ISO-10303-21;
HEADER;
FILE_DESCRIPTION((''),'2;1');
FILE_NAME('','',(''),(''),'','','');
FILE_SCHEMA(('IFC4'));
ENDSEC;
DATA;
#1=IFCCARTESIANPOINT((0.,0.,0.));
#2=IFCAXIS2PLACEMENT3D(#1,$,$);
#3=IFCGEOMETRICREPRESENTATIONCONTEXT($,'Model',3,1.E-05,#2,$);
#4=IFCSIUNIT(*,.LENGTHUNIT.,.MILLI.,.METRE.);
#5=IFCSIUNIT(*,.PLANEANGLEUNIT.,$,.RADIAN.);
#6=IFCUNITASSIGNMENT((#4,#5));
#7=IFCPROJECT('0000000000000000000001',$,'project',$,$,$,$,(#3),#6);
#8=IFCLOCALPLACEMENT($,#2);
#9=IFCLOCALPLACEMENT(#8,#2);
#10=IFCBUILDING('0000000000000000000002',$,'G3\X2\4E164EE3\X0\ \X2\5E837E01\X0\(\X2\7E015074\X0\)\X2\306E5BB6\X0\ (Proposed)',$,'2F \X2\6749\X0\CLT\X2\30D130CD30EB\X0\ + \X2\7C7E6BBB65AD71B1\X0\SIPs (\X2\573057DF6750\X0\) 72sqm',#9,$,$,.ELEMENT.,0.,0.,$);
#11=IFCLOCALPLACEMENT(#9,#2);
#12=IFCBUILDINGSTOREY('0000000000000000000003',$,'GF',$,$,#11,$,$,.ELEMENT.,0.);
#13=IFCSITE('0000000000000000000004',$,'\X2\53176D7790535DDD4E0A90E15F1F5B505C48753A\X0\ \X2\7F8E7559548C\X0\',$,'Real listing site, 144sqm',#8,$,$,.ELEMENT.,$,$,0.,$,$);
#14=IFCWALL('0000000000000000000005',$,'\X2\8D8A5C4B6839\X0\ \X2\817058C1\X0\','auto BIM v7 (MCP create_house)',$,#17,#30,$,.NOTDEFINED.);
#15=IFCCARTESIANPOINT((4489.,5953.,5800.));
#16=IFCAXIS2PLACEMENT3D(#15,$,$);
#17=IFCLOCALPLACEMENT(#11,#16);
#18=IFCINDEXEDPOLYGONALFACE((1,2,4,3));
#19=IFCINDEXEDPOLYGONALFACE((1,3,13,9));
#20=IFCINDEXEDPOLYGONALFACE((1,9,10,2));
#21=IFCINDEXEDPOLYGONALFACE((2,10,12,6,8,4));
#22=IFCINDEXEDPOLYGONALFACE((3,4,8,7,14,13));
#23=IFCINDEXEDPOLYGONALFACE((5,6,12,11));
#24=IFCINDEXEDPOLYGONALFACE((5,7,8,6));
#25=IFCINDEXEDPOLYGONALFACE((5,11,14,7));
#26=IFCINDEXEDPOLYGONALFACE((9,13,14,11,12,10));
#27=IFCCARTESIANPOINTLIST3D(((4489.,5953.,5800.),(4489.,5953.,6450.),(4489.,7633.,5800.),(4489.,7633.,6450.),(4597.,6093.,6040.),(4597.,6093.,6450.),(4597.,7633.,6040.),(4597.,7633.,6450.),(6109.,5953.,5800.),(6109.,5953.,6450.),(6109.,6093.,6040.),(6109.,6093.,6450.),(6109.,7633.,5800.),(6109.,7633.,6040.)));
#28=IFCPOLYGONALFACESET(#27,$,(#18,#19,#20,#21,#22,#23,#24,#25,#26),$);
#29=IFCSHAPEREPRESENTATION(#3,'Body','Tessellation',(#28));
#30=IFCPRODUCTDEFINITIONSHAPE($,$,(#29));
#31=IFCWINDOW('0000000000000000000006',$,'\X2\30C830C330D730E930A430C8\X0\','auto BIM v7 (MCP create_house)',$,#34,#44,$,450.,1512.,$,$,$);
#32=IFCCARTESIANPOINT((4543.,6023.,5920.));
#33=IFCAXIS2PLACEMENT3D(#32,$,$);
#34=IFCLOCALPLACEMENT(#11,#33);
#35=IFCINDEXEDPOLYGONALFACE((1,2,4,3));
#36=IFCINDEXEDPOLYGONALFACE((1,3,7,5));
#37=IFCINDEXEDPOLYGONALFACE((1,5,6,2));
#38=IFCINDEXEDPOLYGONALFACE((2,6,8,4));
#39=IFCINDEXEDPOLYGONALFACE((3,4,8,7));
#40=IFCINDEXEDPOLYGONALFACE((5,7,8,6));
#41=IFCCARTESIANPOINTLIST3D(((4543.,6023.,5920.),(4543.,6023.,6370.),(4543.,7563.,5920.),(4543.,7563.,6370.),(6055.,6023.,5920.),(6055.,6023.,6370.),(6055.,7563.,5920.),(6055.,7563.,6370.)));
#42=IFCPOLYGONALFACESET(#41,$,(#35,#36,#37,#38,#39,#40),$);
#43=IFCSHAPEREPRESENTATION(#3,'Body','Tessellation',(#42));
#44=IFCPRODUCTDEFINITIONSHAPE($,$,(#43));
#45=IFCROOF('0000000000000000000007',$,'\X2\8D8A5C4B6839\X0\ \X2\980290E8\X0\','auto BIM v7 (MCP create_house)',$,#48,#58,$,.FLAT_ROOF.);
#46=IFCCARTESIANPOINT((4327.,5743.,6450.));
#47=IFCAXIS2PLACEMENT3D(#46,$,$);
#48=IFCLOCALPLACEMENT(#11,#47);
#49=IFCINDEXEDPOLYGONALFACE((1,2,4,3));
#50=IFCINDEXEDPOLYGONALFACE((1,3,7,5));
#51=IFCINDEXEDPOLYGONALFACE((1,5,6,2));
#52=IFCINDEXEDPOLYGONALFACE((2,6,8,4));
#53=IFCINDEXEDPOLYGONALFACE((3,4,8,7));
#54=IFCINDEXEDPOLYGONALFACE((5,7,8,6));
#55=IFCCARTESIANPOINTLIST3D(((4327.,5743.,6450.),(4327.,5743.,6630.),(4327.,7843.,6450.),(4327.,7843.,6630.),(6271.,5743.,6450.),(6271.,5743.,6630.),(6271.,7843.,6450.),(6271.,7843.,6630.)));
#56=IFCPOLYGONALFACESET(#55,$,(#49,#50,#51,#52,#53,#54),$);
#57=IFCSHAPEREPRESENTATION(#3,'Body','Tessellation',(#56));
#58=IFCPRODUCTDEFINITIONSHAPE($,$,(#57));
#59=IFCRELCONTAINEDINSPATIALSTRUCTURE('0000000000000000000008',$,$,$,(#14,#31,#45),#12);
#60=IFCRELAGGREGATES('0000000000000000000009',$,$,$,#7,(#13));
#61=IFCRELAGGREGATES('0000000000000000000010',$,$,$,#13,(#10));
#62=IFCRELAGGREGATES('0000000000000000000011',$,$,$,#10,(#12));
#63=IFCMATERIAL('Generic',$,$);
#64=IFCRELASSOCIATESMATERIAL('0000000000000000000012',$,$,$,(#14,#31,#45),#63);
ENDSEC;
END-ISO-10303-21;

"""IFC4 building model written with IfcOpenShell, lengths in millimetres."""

from ifc_helpers import new_model, si_unit, frame, frame_2d, origin, place, context, project, spatial, rectangle, extrude, material, element, fill, save


model = new_model("IFC4")

# Units and contexts
model_context = context("Model", 3, precision=1e-05, world=origin())
ifc_project = project(units=[si_unit("LENGTHUNIT", "METRE", prefix="MILLI"), si_unit("PLANEANGLEUNIT", "RADIAN")], contexts=[model_context])

# Site, building, storey
site_placement = place(None, origin())
site = spatial("IfcSite", under=ifc_project, at=site_placement, Name="北海道川上郡弟子屈町 美留和", ObjectType="Real listing site, 144sqm", CompositionType="ELEMENT", RefElevation=0.0)
building_placement = place(site_placement, origin())
building = spatial("IfcBuilding", under=site, at=building_placement, Name="G3世代 広縁(縁側)の家 (Proposed)", ObjectType="2F 杉CLTパネル + 籾殻断熱SIPs (地域材) 72sqm", CompositionType="ELEMENT", ElevationOfRefHeight=0.0, ElevationOfTerrain=0.0)
storey_placement = place(building_placement, origin())
storey = spatial("IfcBuildingStorey", under=building, at=storey_placement, Name="GF", CompositionType="ELEMENT", Elevation=0.0)

# Shared definitions
ifc_material = material(Name="Generic")

# Wall, opening, window
wall_1_placement = place(storey_placement, frame((4489.0, 5953.0, 5800.0)))
wall_1 = element("IfcWall", 1, at=wall_1_placement, inside=storey, material=ifc_material, Name="越屋根 腰壁", Description="auto BIM v7 (MCP create_house)", PredefinedType="NOTDEFINED", context=model_context, shape_type="SweptSolid", body=[
    extrude(rectangle(XDim=1620.0, YDim=1680.0, at=frame_2d((810.0, 840.0))), frame((4489.0, 5953.0, 5800.0)), (0.0, 0.0, 1.0), 650.0),
])
opening_1_placement = place(storey_placement, frame((4543.0, 6023.0, 5920.0)))
opening_1 = element("IfcOpeningElement", 2, at=opening_1_placement, cuts=wall_1, PredefinedType="NOTDEFINED", context=model_context, shape_type="SweptSolid", body=[
    extrude(rectangle(XDim=1512.0, YDim=1540.0, at=frame_2d((756.0, 770.0))), frame((4543.0, 6023.0, 5920.0)), (0.0, 0.0, 1.0), 450.0),
])
window_1_placement = place(storey_placement, frame((4543.0, 6023.0, 5920.0)))
window_1 = element("IfcWindow", 3, at=window_1_placement, inside=storey, material=ifc_material, Name="トップライト", Description="auto BIM v7 (MCP create_house)", OverallHeight=450.0, OverallWidth=1512.0, context=model_context, shape_type="SweptSolid", body=[
    extrude(rectangle(XDim=1512.0, YDim=1540.0, at=frame_2d((756.0, 770.0))), frame((4543.0, 6023.0, 5920.0)), (0.0, 0.0, 1.0), 450.0),
])
fill(opening_1, window_1)

# Roof
roof_placement = place(storey_placement, frame((4327.0, 5743.0, 6450.0)))
element("IfcRoof", 4, at=roof_placement, inside=storey, material=ifc_material, Name="越屋根 頂部", Description="auto BIM v7 (MCP create_house)", PredefinedType="FLAT_ROOF", context=model_context, shape_type="SweptSolid", body=[
    extrude(rectangle(XDim=1944.0, YDim=2100.0, at=frame_2d((972.0, 1050.0))), frame((4327.0, 5743.0, 6450.0)), (0.0, 0.0, 1.0), 180.0),
])

save(model, "model.ifc")
